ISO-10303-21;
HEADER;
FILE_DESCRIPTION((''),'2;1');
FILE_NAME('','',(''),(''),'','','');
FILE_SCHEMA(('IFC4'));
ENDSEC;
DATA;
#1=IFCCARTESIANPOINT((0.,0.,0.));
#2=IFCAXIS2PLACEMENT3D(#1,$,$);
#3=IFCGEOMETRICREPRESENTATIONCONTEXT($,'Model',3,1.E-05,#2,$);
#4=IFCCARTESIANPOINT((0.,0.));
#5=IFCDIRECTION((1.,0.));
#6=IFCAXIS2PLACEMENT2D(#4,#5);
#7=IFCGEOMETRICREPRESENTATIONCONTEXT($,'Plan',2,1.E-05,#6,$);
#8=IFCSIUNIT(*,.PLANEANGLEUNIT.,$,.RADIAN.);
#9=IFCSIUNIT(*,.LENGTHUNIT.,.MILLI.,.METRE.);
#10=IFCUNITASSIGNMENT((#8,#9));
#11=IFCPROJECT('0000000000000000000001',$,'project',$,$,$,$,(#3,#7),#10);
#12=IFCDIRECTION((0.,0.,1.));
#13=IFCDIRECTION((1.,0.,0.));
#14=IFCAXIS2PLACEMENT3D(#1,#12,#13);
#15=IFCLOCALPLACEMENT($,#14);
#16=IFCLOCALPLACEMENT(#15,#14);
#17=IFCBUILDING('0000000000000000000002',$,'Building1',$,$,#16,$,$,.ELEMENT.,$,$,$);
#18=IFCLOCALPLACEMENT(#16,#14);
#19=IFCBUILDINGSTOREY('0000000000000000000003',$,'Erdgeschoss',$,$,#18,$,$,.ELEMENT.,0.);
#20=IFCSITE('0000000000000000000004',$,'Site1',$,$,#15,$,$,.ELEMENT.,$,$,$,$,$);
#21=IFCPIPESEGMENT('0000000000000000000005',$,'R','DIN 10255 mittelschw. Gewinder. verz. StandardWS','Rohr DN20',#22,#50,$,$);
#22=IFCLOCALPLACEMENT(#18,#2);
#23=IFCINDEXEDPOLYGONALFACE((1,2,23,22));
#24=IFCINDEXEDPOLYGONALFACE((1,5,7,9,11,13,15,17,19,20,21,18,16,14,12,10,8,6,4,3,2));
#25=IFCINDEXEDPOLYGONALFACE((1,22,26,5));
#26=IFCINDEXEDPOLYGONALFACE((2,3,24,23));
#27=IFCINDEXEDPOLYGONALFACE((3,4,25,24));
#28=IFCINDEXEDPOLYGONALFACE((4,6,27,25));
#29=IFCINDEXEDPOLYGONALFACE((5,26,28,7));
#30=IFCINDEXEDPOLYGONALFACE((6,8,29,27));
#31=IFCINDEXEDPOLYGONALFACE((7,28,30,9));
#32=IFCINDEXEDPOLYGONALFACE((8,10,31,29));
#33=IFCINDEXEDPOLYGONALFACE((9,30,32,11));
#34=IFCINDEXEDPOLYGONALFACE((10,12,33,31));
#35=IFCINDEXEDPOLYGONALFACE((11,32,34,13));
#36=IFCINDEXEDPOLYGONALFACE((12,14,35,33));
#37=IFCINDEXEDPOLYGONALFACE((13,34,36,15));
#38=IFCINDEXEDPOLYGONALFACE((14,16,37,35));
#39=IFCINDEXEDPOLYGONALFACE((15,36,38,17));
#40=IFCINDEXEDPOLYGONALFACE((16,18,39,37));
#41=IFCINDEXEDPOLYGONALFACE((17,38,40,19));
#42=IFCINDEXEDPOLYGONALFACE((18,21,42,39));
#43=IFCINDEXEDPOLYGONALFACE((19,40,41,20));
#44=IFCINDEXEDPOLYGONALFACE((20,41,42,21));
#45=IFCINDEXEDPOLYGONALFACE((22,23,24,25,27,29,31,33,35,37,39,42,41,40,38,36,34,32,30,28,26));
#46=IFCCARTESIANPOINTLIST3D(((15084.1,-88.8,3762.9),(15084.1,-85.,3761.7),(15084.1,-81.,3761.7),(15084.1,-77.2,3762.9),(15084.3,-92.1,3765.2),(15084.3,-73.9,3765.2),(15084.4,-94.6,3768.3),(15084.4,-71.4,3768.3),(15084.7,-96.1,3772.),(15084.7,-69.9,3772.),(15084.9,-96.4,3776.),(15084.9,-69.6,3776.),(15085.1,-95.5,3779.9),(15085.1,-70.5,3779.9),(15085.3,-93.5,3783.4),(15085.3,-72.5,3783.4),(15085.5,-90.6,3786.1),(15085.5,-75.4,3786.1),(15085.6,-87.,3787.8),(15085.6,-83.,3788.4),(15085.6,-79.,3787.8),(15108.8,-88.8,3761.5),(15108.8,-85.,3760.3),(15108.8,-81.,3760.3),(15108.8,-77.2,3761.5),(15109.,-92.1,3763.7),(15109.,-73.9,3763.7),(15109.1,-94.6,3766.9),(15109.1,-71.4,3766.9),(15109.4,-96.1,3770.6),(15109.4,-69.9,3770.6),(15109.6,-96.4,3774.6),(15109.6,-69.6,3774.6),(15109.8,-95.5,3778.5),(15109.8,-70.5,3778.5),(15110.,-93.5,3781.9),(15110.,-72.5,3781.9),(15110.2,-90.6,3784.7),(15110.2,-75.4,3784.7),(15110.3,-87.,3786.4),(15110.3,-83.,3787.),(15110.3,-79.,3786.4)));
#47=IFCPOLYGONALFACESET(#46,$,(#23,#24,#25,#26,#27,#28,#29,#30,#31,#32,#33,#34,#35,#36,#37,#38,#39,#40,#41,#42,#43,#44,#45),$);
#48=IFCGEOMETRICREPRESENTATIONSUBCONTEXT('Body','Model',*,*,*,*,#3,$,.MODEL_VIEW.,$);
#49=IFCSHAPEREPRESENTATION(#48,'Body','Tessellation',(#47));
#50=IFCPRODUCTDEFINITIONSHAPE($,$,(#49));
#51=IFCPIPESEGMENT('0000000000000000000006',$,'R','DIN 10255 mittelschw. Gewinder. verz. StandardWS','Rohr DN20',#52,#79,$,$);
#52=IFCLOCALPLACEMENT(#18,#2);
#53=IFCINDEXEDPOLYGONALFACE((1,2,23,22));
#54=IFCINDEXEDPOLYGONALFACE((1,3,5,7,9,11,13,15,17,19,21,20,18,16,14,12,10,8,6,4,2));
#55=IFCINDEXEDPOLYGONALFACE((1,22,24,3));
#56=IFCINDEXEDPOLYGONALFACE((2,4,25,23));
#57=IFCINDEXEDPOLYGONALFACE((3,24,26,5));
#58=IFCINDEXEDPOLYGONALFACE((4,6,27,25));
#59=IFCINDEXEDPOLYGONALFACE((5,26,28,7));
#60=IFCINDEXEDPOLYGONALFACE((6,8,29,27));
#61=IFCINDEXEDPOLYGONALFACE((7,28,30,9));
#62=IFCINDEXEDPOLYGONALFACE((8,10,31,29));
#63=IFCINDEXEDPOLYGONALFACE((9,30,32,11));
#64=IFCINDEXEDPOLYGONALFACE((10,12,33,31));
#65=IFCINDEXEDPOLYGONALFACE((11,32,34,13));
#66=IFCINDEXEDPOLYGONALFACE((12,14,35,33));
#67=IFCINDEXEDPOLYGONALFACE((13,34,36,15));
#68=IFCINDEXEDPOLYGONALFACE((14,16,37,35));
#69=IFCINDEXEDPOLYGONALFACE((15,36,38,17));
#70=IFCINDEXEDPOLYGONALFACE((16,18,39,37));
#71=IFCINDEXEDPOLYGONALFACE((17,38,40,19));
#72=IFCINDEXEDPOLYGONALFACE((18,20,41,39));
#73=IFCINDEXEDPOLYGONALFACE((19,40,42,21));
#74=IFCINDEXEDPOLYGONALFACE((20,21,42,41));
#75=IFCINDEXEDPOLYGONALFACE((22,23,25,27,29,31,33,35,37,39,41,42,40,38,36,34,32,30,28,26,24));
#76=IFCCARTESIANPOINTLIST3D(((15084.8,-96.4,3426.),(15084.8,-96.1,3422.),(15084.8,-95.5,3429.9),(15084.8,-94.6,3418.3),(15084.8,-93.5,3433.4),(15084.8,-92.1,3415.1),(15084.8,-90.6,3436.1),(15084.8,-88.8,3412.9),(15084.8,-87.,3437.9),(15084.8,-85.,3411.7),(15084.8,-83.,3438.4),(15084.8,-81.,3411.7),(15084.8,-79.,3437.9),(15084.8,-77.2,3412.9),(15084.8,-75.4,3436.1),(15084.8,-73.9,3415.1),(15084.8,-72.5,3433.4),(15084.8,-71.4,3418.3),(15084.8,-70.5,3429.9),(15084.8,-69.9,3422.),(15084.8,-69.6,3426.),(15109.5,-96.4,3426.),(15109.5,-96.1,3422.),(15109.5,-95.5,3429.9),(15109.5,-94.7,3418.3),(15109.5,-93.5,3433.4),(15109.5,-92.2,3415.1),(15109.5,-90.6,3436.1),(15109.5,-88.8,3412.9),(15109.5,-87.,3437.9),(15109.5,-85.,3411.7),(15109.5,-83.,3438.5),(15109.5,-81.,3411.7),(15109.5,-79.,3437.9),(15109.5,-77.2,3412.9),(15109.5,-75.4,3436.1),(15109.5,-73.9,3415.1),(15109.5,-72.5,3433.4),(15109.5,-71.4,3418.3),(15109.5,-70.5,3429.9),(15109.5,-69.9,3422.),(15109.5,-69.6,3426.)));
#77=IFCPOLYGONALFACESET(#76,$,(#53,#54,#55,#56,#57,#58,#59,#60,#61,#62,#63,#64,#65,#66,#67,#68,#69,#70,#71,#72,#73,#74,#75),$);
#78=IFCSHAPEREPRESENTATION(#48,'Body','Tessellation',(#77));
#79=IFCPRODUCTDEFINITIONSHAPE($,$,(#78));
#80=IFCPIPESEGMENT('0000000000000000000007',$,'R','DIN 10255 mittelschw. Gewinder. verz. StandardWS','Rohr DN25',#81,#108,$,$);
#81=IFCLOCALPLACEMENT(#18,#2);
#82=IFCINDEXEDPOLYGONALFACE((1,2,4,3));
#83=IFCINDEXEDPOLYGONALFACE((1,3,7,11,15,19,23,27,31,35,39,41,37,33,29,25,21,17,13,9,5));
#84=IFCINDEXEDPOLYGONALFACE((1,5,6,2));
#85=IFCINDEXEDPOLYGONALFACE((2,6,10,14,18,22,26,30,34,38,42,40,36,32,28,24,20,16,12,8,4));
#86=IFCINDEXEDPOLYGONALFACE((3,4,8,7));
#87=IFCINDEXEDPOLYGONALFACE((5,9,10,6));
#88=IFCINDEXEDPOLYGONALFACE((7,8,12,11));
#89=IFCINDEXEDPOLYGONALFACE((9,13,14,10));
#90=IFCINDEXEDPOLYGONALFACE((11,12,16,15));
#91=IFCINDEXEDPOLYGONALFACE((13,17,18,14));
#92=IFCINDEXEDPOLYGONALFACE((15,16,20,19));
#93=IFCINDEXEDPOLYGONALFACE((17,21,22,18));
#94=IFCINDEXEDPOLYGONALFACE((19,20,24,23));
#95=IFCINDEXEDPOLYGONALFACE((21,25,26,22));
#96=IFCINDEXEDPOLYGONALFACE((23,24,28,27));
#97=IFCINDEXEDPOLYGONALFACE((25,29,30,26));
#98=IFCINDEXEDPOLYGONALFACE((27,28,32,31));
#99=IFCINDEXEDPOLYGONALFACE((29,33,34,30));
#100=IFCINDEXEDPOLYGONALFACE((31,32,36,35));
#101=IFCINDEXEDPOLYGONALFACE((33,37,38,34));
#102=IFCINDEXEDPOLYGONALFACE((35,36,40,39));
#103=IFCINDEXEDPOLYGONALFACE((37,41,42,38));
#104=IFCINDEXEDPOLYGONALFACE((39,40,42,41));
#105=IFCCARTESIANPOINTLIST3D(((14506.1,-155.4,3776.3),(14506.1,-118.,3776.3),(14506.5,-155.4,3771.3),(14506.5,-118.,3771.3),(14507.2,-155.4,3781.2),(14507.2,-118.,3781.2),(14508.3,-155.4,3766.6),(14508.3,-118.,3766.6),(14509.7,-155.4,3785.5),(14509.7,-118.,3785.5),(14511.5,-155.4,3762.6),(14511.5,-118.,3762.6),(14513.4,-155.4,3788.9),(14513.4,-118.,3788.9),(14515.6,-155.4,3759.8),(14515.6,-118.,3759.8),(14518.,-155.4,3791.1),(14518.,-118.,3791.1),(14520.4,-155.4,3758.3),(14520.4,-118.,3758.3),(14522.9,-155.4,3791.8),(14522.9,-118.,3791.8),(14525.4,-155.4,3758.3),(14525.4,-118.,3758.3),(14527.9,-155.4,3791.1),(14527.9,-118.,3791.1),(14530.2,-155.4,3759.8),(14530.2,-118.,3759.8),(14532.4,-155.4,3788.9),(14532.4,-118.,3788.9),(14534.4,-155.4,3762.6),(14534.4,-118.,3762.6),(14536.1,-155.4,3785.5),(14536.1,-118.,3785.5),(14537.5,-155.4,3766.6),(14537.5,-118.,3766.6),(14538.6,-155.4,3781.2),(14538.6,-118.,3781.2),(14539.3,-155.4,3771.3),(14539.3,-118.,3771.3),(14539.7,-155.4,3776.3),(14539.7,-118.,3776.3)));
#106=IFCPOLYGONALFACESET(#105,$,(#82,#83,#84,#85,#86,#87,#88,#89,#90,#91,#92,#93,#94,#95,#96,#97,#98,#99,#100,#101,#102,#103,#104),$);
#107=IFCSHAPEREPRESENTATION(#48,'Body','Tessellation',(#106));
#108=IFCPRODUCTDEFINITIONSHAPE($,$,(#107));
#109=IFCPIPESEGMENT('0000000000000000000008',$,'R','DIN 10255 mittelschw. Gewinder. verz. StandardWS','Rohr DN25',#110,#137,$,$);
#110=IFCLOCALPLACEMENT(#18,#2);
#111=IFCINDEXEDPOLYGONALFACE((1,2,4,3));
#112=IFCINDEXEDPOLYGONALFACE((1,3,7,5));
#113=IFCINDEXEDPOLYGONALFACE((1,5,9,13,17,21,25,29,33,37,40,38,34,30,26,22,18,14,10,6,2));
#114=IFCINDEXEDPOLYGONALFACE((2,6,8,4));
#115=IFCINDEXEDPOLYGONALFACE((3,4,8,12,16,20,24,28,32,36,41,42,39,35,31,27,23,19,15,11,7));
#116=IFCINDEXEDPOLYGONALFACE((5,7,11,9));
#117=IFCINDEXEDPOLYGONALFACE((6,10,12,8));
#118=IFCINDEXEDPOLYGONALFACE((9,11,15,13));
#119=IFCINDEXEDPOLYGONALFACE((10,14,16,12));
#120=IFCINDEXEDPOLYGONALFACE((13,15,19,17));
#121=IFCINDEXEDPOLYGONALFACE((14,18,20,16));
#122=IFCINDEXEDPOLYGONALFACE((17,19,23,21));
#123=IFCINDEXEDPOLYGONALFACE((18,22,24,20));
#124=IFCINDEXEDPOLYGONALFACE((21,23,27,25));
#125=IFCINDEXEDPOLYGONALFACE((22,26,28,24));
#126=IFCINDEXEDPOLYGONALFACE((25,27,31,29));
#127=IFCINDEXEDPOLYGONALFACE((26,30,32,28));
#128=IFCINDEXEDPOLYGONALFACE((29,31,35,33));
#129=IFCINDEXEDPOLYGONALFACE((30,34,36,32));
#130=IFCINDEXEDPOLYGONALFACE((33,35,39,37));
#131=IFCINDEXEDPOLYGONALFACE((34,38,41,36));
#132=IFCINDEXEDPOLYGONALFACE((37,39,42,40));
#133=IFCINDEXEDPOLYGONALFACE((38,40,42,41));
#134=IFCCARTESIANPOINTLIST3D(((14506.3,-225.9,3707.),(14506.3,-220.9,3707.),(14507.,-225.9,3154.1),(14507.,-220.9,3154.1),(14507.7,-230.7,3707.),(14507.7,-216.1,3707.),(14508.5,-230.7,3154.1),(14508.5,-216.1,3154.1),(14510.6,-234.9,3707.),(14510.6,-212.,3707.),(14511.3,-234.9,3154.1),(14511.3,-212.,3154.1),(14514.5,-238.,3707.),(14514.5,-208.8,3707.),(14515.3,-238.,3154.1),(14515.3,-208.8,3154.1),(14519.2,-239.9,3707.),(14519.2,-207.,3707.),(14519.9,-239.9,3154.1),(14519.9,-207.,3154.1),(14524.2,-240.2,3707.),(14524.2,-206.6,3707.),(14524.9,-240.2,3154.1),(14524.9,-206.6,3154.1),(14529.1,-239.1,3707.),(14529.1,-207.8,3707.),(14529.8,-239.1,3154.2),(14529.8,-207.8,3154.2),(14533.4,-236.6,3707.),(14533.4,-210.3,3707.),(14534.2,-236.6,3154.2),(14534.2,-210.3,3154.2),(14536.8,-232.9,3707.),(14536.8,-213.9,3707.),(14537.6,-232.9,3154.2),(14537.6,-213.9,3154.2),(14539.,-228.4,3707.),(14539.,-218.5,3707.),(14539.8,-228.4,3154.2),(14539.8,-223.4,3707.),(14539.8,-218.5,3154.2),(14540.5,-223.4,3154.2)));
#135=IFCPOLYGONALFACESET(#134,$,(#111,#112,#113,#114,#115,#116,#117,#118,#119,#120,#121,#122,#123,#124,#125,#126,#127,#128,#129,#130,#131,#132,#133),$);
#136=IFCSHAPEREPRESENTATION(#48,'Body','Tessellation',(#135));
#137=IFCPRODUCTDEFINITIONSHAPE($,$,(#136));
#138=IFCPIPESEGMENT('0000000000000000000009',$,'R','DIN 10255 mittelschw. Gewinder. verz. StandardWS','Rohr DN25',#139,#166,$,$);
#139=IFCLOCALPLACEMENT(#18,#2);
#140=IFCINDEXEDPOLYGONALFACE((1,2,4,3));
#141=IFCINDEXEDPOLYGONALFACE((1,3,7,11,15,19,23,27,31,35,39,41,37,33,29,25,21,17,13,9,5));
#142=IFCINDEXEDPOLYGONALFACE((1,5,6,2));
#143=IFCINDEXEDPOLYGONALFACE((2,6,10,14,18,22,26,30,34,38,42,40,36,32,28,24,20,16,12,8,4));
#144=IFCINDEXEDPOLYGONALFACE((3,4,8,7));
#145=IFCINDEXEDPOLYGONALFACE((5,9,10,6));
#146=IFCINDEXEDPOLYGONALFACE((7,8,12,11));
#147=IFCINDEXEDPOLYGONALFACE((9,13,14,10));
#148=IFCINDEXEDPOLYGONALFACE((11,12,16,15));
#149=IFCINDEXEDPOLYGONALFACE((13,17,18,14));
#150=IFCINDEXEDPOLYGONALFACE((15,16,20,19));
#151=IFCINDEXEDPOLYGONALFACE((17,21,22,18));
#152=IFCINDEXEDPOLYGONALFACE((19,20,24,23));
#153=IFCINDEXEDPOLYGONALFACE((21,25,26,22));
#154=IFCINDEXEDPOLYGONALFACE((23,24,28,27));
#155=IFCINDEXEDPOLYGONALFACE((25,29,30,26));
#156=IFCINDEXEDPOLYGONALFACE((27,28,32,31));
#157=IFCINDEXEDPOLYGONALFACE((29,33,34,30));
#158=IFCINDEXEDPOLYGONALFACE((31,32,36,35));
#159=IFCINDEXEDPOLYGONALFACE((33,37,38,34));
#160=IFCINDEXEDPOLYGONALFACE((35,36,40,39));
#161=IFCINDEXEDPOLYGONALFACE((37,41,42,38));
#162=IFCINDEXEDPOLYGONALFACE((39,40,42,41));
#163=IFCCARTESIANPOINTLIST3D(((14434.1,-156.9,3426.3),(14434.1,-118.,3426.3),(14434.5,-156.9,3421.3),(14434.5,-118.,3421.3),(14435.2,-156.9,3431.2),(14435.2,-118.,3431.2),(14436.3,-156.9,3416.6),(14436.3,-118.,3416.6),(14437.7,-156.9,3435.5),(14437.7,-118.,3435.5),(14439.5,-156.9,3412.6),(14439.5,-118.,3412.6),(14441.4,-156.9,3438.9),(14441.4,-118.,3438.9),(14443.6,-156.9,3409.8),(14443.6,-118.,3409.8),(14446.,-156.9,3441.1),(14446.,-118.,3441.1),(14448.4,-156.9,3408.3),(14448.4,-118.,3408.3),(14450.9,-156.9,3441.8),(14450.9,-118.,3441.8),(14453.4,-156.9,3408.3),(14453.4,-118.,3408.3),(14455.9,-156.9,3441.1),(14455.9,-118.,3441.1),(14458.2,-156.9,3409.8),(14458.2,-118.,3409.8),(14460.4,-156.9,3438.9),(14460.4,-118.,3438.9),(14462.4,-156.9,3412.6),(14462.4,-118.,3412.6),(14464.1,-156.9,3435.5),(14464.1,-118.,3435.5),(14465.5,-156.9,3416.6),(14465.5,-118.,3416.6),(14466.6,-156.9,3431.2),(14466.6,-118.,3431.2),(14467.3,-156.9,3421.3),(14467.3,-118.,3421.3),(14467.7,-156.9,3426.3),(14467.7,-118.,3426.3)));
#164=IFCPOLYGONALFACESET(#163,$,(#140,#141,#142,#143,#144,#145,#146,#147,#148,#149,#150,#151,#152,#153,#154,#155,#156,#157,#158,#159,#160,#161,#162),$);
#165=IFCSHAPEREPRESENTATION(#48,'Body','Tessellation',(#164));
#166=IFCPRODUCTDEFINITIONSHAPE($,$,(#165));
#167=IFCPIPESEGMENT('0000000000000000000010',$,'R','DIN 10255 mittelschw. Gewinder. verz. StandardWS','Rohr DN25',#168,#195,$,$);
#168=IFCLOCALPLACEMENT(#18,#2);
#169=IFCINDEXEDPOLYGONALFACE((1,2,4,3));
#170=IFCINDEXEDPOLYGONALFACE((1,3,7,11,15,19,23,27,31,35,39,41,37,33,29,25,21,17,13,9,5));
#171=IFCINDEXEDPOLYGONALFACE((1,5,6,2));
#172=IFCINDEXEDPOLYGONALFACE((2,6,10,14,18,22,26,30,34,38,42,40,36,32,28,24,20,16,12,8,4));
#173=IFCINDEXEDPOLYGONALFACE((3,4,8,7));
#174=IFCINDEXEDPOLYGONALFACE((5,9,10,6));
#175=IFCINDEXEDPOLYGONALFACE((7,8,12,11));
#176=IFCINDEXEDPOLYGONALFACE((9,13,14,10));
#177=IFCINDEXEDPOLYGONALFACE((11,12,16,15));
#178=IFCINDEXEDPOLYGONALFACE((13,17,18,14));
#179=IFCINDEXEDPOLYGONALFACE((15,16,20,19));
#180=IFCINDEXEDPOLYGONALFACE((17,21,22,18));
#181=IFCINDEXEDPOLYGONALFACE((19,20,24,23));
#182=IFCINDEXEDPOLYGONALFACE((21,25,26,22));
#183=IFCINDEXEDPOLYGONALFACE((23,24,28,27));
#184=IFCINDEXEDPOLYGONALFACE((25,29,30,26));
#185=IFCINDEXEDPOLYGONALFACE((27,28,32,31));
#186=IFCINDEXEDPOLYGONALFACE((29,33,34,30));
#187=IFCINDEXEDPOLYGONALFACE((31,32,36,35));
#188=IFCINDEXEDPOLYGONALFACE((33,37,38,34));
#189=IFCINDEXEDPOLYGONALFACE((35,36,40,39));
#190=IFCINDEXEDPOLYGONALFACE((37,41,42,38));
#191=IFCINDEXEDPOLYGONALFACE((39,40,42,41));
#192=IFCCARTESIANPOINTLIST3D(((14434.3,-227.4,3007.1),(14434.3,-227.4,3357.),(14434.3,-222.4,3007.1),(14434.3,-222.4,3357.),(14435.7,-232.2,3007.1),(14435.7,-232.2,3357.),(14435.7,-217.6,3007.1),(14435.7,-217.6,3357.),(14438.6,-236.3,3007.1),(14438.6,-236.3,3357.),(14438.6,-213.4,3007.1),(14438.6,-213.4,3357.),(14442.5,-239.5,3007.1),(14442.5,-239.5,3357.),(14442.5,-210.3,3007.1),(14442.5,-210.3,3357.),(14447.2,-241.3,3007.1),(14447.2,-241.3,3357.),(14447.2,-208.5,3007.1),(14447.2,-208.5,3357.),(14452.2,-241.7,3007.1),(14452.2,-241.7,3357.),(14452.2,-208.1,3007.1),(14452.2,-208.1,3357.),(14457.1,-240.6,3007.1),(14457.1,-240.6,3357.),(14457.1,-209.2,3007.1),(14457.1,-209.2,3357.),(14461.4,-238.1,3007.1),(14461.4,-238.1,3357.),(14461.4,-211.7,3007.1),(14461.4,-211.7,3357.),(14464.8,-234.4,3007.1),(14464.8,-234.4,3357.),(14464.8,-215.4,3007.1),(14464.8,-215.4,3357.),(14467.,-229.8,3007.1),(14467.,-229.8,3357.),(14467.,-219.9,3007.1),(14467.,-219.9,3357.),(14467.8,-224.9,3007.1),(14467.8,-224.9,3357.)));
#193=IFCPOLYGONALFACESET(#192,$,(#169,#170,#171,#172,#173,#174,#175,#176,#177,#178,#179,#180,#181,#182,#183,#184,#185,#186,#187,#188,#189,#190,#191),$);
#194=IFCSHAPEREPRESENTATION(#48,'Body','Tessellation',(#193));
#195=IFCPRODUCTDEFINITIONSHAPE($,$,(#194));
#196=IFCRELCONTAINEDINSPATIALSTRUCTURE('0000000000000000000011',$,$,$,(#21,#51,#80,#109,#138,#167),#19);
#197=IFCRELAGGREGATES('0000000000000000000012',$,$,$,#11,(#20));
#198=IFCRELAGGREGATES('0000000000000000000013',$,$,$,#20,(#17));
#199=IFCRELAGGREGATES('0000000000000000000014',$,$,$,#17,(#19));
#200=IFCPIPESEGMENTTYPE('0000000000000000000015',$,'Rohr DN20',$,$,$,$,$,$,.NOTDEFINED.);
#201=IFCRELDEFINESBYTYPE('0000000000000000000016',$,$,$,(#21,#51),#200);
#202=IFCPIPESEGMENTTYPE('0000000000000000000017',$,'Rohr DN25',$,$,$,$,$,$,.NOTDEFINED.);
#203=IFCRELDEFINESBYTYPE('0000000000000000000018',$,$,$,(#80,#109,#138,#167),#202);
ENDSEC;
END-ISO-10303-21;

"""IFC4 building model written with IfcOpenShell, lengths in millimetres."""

from ifc_helpers import new_model, si_unit, frame, origin, origin_with_axes, origin_2d_with_axis, place, context, subcontext, project, spatial, circle, extrude, type_object, element, save


model = new_model("IFC4")

# Units and contexts
model_context = context("Model", 3, precision=1e-05, world=origin())
plan_context = context("Plan", 2, precision=1e-05, world=origin_2d_with_axis())
body_context = subcontext(model_context, "Body", "Model", "MODEL_VIEW")
ifc_project = project(units=[si_unit("PLANEANGLEUNIT", "RADIAN"), si_unit("LENGTHUNIT", "METRE", prefix="MILLI")], contexts=[model_context, plan_context])

# Site, building, storey
site_placement = place(None, origin_with_axes())
site = spatial("IfcSite", under=ifc_project, at=site_placement, Name="Site1", CompositionType="ELEMENT")
building_placement = place(site_placement, origin_with_axes())
building = spatial("IfcBuilding", under=site, at=building_placement, Name="Building1", CompositionType="ELEMENT")
storey_placement = place(building_placement, origin_with_axes())
storey = spatial("IfcBuildingStorey", under=building, at=storey_placement, Name="Erdgeschoss", CompositionType="ELEMENT", Elevation=0.0)

# Pipe segments
pipe_segment_type_1 = type_object("IfcPipeSegmentType", Name="Rohr DN20", PredefinedType="NOTDEFINED")
pipe_segment_1_placement = place(storey_placement, frame((15097.2, -83.2, 3774.3), z_axis=(0.0, 0.0, 1.0), x_axis=(1.0, 0.0, 0.0)))
element("IfcPipeSegment", 1, at=pipe_segment_1_placement, inside=storey, type_object=pipe_segment_type_1, Name="R", Description="DIN 10255 mittelschw. Gewinder. verz. StandardWS", ObjectType="Rohr DN20", context=body_context, shape_type="SolidModel", body=[
    extrude(circle(Radius=13.4, at=origin_2d_with_axis()), frame((12.4, 0.1, -0.7), z_axis=(-0.998342, 0.0, 0.057556), x_axis=(0.0, 0.0, 1.0)), (0.0, 0.0, 1.0), 24.8),
])
pipe_segment_2_placement = place(storey_placement, frame((15097.2, -83.2, 3425.0), z_axis=(0.0, 0.0, 1.0), x_axis=(1.0, 0.0, 0.0)))
element("IfcPipeSegment", 2, at=pipe_segment_2_placement, inside=storey, type_object=pipe_segment_type_1, Name="R", Description="DIN 10255 mittelschw. Gewinder. verz. StandardWS", ObjectType="Rohr DN20", context=body_context, shape_type="SolidModel", body=[
    extrude(circle(Radius=13.4, at=origin_2d_with_axis()), frame((12.3, 0.1, 0.0), z_axis=(-1.0, 0.000133, -0.000096), x_axis=(0.0, 0.0, 1.0)), (0.0, 0.0, 1.0), 24.7),
])
pipe_segment_type_2 = type_object("IfcPipeSegmentType", Name="Rohr DN25", PredefinedType="NOTDEFINED")
pipe_segment_3_placement = place(storey_placement, frame((14523.1, -136.7, 3775.0), z_axis=(0.0, 0.0, 1.0), x_axis=(1.0, 0.0, 0.0)))
element("IfcPipeSegment", 3, at=pipe_segment_3_placement, inside=storey, type_object=pipe_segment_type_2, Name="R", Description="DIN 10255 mittelschw. Gewinder. verz. StandardWS", ObjectType="Rohr DN25", context=body_context, shape_type="SolidModel", body=[
    extrude(circle(Radius=16.9, at=origin_2d_with_axis()), frame((-0.1, 18.7, 0.0), z_axis=(0.0, -1.0, 0.0), x_axis=(0.0, 0.0, 1.0)), (0.0, 0.0, 1.0), 37.4),
])
pipe_segment_4_placement = place(storey_placement, frame((14523.3, -223.3, 3430.6), z_axis=(0.0, 0.0, 1.0), x_axis=(1.0, 0.0, 0.0)))
element("IfcPipeSegment", 4, at=pipe_segment_4_placement, inside=storey, type_object=pipe_segment_type_2, Name="R", Description="DIN 10255 mittelschw. Gewinder. verz. StandardWS", ObjectType="Rohr DN25", context=body_context, shape_type="SolidModel", body=[
    extrude(circle(Radius=16.9, at=origin_2d_with_axis()), frame((-0.4, -0.2, 276.4), z_axis=(0.001364, 0.0, -0.999999), x_axis=(1.0, 0.0, 0.0)), (0.0, 0.0, 1.0), 552.9),
])
pipe_segment_5_placement = place(storey_placement, frame((14451.1, -137.4, 3425.0), z_axis=(0.0, 0.0, 1.0), x_axis=(1.0, 0.0, 0.0)))
element("IfcPipeSegment", 5, at=pipe_segment_5_placement, inside=storey, type_object=pipe_segment_type_2, Name="R", Description="DIN 10255 mittelschw. Gewinder. verz. StandardWS", ObjectType="Rohr DN25", context=body_context, shape_type="SolidModel", body=[
    extrude(circle(Radius=16.9, at=origin_2d_with_axis()), frame((-0.1, 19.4, 0.0), z_axis=(0.0, -1.0, 0.0), x_axis=(0.0, 0.0, 1.0)), (0.0, 0.0, 1.0), 38.9),
])
pipe_segment_6_placement = place(storey_placement, frame((14450.9, -224.7, 3182.1), z_axis=(0.0, 0.0, 1.0), x_axis=(1.0, 0.0, 0.0)))
element("IfcPipeSegment", 6, at=pipe_segment_6_placement, inside=storey, type_object=pipe_segment_type_2, Name="R", Description="DIN 10255 mittelschw. Gewinder. verz. StandardWS", ObjectType="Rohr DN25", context=body_context, shape_type="SolidModel", body=[
    extrude(circle(Radius=16.9, at=origin_2d_with_axis()), frame((0.0, -0.2, 174.9), z_axis=(0.0, 0.0, -1.0), x_axis=(1.0, 0.0, 0.0)), (0.0, 0.0, 1.0), 349.9),
])

save(model, "model.ifc")
